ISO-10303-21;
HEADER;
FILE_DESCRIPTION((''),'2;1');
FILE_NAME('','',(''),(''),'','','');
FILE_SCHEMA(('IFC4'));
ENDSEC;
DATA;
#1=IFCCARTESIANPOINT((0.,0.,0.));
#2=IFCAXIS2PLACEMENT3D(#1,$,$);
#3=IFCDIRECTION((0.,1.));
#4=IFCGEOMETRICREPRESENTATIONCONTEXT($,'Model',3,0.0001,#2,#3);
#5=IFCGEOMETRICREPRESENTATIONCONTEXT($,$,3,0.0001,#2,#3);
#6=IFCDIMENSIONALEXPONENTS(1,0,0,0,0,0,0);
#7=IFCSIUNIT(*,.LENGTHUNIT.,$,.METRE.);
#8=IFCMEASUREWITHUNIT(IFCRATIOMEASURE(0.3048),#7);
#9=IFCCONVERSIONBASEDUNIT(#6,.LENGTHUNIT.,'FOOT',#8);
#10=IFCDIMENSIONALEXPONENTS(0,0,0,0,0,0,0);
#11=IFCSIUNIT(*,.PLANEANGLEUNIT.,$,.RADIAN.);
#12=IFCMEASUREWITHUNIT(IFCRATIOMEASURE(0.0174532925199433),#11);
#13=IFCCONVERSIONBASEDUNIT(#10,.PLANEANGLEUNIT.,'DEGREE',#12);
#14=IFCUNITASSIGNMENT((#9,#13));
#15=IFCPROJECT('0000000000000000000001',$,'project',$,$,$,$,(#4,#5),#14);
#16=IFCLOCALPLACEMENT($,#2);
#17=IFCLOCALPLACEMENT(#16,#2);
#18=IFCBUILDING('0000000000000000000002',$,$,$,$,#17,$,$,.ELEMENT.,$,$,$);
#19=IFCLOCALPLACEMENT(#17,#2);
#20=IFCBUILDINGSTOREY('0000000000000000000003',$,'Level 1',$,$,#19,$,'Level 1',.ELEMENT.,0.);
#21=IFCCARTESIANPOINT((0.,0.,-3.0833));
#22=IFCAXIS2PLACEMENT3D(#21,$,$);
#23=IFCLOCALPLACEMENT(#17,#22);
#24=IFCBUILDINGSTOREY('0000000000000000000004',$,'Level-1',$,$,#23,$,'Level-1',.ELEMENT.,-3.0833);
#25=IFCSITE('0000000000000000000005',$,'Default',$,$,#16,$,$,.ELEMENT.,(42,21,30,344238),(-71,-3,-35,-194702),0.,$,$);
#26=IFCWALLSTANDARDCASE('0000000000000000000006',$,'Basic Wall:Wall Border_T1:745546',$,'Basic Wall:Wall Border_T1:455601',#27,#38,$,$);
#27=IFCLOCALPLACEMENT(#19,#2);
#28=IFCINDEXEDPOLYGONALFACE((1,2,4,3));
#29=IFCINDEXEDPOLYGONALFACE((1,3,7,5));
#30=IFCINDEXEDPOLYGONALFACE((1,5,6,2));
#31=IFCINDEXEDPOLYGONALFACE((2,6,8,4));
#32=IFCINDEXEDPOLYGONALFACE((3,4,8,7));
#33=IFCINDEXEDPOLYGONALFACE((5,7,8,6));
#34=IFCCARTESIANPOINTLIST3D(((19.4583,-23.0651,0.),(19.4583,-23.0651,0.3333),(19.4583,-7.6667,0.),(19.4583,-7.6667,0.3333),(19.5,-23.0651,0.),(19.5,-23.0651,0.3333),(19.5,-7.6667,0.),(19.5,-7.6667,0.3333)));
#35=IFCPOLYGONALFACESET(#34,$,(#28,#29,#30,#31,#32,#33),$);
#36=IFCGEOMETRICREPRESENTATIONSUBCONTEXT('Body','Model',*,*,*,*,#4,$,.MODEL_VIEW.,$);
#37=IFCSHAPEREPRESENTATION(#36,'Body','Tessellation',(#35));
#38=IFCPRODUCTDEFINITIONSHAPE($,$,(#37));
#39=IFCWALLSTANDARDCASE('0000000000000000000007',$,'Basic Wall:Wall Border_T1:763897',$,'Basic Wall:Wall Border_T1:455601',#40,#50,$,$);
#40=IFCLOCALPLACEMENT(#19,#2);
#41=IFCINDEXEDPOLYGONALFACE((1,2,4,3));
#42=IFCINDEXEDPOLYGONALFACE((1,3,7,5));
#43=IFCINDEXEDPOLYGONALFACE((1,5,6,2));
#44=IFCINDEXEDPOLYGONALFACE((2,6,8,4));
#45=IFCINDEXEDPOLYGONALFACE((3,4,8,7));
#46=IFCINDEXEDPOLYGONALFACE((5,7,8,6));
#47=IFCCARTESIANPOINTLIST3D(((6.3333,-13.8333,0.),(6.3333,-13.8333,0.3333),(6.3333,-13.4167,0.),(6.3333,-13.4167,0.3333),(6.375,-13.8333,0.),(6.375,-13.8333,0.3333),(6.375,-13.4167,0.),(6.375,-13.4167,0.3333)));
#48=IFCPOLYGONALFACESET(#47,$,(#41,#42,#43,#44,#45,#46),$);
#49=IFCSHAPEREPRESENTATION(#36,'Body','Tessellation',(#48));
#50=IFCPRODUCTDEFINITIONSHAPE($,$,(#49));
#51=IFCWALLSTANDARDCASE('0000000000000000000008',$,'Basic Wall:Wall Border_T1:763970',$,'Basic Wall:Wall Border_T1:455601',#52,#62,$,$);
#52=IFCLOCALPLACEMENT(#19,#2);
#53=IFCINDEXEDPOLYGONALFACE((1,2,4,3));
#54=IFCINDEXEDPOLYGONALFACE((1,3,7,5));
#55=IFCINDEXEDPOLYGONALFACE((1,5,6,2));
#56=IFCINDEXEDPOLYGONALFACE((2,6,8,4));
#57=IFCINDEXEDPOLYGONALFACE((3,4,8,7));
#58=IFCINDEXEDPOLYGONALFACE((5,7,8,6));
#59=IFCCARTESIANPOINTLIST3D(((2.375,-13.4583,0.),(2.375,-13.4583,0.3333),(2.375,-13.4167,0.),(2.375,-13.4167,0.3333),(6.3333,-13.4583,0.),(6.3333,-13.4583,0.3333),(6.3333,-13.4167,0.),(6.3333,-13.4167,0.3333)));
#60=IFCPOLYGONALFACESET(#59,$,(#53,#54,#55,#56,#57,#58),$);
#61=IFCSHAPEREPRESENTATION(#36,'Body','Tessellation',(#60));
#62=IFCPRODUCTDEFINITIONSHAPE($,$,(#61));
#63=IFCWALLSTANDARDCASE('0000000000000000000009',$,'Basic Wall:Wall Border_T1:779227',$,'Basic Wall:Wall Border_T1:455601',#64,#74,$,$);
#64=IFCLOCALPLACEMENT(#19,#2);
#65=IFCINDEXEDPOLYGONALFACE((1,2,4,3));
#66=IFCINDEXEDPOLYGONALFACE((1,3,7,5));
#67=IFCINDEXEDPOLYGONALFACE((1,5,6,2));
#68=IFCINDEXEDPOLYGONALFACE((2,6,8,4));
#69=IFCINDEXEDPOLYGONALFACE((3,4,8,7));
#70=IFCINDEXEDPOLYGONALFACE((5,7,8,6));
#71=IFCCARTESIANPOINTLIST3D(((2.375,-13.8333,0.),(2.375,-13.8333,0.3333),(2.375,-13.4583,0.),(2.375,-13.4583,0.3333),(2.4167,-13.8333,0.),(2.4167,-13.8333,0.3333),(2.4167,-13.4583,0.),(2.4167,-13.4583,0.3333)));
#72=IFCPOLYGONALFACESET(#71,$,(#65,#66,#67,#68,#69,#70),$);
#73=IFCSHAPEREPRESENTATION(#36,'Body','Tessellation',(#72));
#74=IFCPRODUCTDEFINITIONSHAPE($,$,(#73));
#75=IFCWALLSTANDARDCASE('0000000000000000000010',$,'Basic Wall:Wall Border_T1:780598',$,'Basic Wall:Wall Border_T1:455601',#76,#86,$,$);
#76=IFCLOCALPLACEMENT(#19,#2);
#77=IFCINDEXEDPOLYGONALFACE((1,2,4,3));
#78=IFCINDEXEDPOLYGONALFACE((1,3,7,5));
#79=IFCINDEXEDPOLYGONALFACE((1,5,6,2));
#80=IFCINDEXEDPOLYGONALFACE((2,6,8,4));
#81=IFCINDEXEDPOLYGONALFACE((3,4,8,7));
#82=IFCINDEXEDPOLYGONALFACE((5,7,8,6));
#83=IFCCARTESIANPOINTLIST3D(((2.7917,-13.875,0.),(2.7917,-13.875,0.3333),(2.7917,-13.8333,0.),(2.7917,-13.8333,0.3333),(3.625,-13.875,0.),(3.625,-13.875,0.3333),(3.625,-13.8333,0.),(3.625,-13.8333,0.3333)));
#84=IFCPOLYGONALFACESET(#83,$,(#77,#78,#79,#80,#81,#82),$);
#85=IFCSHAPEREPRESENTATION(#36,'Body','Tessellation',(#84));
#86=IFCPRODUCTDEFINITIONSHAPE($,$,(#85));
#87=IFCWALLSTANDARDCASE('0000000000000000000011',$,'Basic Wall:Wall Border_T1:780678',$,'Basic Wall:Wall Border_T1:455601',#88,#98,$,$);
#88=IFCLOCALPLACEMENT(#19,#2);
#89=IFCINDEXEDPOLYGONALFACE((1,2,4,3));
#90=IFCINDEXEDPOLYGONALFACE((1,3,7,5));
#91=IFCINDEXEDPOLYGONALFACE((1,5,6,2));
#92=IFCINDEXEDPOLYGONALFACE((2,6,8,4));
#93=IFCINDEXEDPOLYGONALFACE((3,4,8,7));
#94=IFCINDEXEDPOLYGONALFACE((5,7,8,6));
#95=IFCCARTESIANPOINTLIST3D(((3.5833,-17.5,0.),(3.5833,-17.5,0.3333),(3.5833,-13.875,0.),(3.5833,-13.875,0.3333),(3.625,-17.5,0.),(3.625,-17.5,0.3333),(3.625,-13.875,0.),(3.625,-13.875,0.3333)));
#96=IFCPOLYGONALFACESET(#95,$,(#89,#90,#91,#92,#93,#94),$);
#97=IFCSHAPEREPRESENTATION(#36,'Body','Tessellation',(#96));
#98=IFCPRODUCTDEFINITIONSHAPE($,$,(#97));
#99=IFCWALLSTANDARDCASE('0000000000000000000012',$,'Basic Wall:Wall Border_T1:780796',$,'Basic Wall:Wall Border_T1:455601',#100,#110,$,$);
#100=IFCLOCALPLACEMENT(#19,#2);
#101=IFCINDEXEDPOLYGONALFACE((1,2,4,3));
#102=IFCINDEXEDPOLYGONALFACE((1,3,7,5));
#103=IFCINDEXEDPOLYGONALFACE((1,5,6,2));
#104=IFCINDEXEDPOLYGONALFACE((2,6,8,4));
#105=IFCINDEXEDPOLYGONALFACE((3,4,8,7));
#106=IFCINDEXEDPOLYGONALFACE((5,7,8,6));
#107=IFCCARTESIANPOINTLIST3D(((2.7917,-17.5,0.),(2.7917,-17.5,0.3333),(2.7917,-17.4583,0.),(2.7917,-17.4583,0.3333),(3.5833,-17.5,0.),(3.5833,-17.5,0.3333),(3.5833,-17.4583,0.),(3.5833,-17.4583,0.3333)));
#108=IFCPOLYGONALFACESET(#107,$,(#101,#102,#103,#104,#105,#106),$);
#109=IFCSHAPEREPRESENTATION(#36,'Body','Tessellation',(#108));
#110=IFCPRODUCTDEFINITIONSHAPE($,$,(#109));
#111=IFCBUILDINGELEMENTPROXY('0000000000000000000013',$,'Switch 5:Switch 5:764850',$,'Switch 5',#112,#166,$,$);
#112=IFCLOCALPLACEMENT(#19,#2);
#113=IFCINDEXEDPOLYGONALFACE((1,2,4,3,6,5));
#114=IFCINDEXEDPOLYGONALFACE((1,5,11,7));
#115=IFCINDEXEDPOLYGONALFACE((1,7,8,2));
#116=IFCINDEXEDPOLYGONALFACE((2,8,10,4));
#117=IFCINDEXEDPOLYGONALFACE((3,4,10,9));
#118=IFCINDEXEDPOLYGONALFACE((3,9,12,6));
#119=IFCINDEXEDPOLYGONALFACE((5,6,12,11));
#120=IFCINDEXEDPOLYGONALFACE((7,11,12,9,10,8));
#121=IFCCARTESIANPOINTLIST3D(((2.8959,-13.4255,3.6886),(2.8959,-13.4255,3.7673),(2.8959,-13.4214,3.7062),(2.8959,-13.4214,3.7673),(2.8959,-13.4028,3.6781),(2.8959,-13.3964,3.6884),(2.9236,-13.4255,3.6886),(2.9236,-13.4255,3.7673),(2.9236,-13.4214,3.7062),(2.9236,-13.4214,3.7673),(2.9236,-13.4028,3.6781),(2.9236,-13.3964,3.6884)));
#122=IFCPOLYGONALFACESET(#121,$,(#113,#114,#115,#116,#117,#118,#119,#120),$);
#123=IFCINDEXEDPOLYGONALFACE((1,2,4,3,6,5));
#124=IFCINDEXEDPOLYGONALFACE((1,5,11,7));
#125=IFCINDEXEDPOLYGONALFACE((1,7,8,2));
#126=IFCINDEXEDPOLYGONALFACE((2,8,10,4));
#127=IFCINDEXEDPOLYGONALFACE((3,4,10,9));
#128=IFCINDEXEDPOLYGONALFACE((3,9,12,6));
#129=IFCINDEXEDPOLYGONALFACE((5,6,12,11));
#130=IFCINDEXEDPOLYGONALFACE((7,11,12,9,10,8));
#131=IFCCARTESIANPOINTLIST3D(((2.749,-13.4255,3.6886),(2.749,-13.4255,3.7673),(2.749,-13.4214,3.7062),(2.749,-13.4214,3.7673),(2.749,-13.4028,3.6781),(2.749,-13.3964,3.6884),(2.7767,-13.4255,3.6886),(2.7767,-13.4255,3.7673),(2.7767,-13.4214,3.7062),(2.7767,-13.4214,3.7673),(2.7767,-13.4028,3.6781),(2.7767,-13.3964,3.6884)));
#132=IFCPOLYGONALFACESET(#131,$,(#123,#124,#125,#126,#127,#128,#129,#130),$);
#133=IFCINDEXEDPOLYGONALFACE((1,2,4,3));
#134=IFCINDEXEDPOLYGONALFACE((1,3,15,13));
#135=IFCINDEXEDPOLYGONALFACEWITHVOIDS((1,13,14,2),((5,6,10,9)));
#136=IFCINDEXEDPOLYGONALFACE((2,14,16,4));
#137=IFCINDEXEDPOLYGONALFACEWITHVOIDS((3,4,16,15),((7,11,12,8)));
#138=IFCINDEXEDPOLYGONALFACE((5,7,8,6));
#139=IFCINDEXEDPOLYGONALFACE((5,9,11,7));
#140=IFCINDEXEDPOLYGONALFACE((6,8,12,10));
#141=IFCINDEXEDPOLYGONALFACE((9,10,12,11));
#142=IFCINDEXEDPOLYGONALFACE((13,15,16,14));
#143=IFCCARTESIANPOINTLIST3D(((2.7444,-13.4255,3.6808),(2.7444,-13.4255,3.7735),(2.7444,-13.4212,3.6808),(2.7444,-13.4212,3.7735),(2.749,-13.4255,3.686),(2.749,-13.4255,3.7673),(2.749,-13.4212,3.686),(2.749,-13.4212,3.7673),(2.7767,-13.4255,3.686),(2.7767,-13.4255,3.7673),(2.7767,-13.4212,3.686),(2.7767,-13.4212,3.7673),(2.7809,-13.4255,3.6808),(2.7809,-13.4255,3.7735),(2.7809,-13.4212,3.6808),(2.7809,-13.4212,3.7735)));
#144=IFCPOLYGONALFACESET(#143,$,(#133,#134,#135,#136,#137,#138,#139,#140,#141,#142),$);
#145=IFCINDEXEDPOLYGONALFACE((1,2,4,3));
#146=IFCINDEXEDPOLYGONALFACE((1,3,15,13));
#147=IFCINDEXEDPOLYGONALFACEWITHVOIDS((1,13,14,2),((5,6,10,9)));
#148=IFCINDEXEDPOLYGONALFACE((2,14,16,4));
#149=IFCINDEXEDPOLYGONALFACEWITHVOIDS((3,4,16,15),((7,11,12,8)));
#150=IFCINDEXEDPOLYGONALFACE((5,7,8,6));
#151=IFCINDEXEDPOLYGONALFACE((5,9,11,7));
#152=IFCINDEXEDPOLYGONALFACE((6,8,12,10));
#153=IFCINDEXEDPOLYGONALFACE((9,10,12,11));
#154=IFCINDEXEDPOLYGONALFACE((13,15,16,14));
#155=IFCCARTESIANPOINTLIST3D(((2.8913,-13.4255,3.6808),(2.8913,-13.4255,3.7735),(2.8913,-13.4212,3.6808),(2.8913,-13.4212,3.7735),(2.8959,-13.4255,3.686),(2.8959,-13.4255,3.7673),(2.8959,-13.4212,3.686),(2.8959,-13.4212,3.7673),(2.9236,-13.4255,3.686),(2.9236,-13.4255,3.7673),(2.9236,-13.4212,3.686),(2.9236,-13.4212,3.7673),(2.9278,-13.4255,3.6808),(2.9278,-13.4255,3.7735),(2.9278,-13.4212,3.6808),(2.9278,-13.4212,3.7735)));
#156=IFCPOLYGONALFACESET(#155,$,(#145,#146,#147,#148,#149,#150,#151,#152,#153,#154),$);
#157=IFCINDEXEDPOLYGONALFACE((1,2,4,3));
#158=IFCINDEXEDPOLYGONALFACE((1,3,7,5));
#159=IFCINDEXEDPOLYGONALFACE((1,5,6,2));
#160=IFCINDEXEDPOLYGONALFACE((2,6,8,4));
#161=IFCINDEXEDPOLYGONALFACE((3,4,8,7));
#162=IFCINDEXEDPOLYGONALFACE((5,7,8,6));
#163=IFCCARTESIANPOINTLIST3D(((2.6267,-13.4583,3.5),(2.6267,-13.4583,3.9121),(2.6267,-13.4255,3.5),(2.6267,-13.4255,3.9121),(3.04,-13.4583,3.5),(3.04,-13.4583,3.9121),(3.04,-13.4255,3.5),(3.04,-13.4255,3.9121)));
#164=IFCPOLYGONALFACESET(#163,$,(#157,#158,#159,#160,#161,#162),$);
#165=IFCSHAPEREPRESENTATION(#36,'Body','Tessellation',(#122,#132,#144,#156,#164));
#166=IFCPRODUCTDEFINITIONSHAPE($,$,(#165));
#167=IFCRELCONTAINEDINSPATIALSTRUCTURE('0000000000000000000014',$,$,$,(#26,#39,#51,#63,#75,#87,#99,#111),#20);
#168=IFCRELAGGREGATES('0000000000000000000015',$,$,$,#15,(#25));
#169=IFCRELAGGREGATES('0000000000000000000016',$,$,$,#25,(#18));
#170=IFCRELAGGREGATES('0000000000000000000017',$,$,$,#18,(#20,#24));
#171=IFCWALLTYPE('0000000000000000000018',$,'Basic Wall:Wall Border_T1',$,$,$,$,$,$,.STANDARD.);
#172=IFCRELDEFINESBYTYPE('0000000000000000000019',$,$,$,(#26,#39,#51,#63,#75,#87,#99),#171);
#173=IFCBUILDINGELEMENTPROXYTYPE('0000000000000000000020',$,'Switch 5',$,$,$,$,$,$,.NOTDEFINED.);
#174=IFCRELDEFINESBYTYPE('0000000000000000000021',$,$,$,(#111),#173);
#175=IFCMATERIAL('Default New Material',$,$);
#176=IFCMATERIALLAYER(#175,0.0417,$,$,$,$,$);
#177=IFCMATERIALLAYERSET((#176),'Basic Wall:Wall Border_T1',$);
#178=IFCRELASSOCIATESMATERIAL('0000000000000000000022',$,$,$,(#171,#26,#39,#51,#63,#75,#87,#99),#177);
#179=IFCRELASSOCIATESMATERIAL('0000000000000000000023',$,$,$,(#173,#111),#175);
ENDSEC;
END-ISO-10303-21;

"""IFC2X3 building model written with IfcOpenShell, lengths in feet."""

from ifc_helpers import new_model, entity, si_unit, converted_unit, direction, frame, frame_2d, origin, origin_2d_with_axis, place, context, subcontext, project, spatial, polyline, rectangle, outline, extrude, source, transform, mapped, material, layer, layer_set, layer_usage, type_object, type_shapes, element, save


model = new_model("IFC2X3")

# Units and contexts
model_context = context("Model", 3, precision=0.0001, world=origin(), true_north=direction((0.0, 1.0)))
context_of_model = context(None, 3, precision=0.0001, world=origin(), true_north=direction((0.0, 1.0)))
body_context = subcontext(model_context, "Body", "Model", "MODEL_VIEW")
ifc_project = project(units=[converted_unit("LENGTHUNIT", "FOOT", entity("IfcRatioMeasure", 0.3048), si_unit("LENGTHUNIT", "METRE"), dimensions=[1, 0, 0, 0, 0, 0, 0]), converted_unit("PLANEANGLEUNIT", "DEGREE", entity("IfcRatioMeasure", 0.0174532925199433), si_unit("PLANEANGLEUNIT", "RADIAN"), dimensions=[0, 0, 0, 0, 0, 0, 0])], contexts=[model_context, context_of_model])

# Site, building, storey
site_placement = place(None, origin())
site = spatial("IfcSite", under=ifc_project, at=site_placement, Name="Default", CompositionType="ELEMENT", RefLatitude=(42, 21, 30, 344238), RefLongitude=(-71, -3, -35, -194702), RefElevation=0.0)
building_placement = place(site_placement, origin())
building = spatial("IfcBuilding", under=site, at=building_placement, CompositionType="ELEMENT")
storey_1_placement = place(building_placement, origin())
storey_1 = spatial("IfcBuildingStorey", under=building, at=storey_1_placement, Name="Level 1", LongName="Level 1", CompositionType="ELEMENT", Elevation=0.0)

# Shared definitions
ifc_material_1 = material(Name="Default New Material")

# Shared definitions
storey_2_placement = place(building_placement, frame((0.0, 0.0, -3.0833)))
storey_2 = spatial("IfcBuildingStorey", under=building, at=storey_2_placement, Name="Level-1", LongName="Level-1", CompositionType="ELEMENT", Elevation=-3.0833)

# Walls
ifc_layer_1 = layer(ifc_material_1, 0.0417)
ifc_layer_set_1 = layer_set([ifc_layer_1], Name="Basic Wall:Wall Border_T1")
wall_type_1 = type_object("IfcWallType", Name="Basic Wall:Wall Border_T1", PredefinedType="STANDARD", material=ifc_layer_set_1)
ifc_layer_usage_1 = layer_usage(ifc_layer_set_1, "AXIS2", "POSITIVE", -0.0208)
wall_1_placement = place(storey_1_placement, frame((19.4792, -7.6667, 0.0), z_axis=(0.0, 0.0, 1.0), x_axis=(0.0, -1.0, 0.0)))
element("IfcWallStandardCase", 1, at=wall_1_placement, inside=storey_1, type_object=wall_type_1, material=ifc_layer_usage_1, Name="Basic Wall:Wall Border_T1:745546", ObjectType="Basic Wall:Wall Border_T1:455601", context=body_context, shape_type="SweptSolid", body=[
    extrude(rectangle(XDim=15.3985, YDim=0.0417, at=frame_2d((7.6992, 0.0), x_axis=(-1.0, 0.0))), origin(), (0.0, 0.0, 1.0), 0.3333),
])
ifc_layer_usage_2 = layer_usage(ifc_layer_set_1, "AXIS2", "POSITIVE", -0.0208)
wall_2_placement = place(storey_1_placement, frame((6.3542, -13.8333, 0.0), z_axis=(0.0, 0.0, 1.0), x_axis=(0.0, 1.0, 0.0)))
element("IfcWallStandardCase", 2, at=wall_2_placement, inside=storey_1, type_object=wall_type_1, material=ifc_layer_usage_2, Name="Basic Wall:Wall Border_T1:763897", ObjectType="Basic Wall:Wall Border_T1:455601", context=body_context, shape_type="SweptSolid", body=[
    extrude(rectangle(XDim=0.4167, YDim=0.0417, at=frame_2d((0.2083, 0.0), x_axis=(-1.0, 0.0))), origin(), (0.0, 0.0, 1.0), 0.3333),
])
ifc_layer_usage_3 = layer_usage(ifc_layer_set_1, "AXIS2", "POSITIVE", -0.0208)
wall_3_placement = place(storey_1_placement, frame((6.3333, -13.4375, 0.0), z_axis=(0.0, 0.0, 1.0), x_axis=(-1.0, 0.0, 0.0)))
element("IfcWallStandardCase", 3, at=wall_3_placement, inside=storey_1, type_object=wall_type_1, material=ifc_layer_usage_3, Name="Basic Wall:Wall Border_T1:763970", ObjectType="Basic Wall:Wall Border_T1:455601", context=body_context, shape_type="SweptSolid", body=[
    extrude(rectangle(XDim=3.9583, YDim=0.0417, at=frame_2d((1.9792, 0.0), x_axis=(-1.0, 0.0))), origin(), (0.0, 0.0, 1.0), 0.3333),
])
ifc_layer_usage_4 = layer_usage(ifc_layer_set_1, "AXIS2", "POSITIVE", -0.0208)
wall_4_placement = place(storey_1_placement, frame((2.3958, -13.4583, 0.0), z_axis=(0.0, 0.0, 1.0), x_axis=(0.0, -1.0, 0.0)))
element("IfcWallStandardCase", 4, at=wall_4_placement, inside=storey_1, type_object=wall_type_1, material=ifc_layer_usage_4, Name="Basic Wall:Wall Border_T1:779227", ObjectType="Basic Wall:Wall Border_T1:455601", context=body_context, shape_type="SweptSolid", body=[
    extrude(rectangle(XDim=0.375, YDim=0.0417, at=frame_2d((0.1875, 0.0), x_axis=(-1.0, 0.0))), origin(), (0.0, 0.0, 1.0), 0.3333),
])
ifc_layer_usage_5 = layer_usage(ifc_layer_set_1, "AXIS2", "POSITIVE", -0.0208)
wall_5_placement = place(storey_1_placement, frame((2.7917, -13.8542, 0.0)))
element("IfcWallStandardCase", 5, at=wall_5_placement, inside=storey_1, type_object=wall_type_1, material=ifc_layer_usage_5, Name="Basic Wall:Wall Border_T1:780598", ObjectType="Basic Wall:Wall Border_T1:455601", context=body_context, shape_type="SweptSolid", body=[
    extrude(rectangle(XDim=0.8333, YDim=0.0417, at=frame_2d((0.4167, 0.0), x_axis=(-1.0, 0.0))), origin(), (0.0, 0.0, 1.0), 0.3333),
])
ifc_layer_usage_6 = layer_usage(ifc_layer_set_1, "AXIS2", "POSITIVE", -0.0208)
wall_6_placement = place(storey_1_placement, frame((3.6042, -13.875, 0.0), z_axis=(0.0, 0.0, 1.0), x_axis=(0.0, -1.0, 0.0)))
element("IfcWallStandardCase", 6, at=wall_6_placement, inside=storey_1, type_object=wall_type_1, material=ifc_layer_usage_6, Name="Basic Wall:Wall Border_T1:780678", ObjectType="Basic Wall:Wall Border_T1:455601", context=body_context, shape_type="SweptSolid", body=[
    extrude(rectangle(XDim=3.625, YDim=0.0417, at=frame_2d((1.8125, 0.0), x_axis=(-1.0, 0.0))), origin(), (0.0, 0.0, 1.0), 0.3333),
])
ifc_layer_usage_7 = layer_usage(ifc_layer_set_1, "AXIS2", "POSITIVE", -0.0208)
wall_7_placement = place(storey_1_placement, frame((3.5833, -17.4792, 0.0), z_axis=(0.0, 0.0, 1.0), x_axis=(-1.0, 0.0, 0.0)))
element("IfcWallStandardCase", 7, at=wall_7_placement, inside=storey_1, type_object=wall_type_1, material=ifc_layer_usage_7, Name="Basic Wall:Wall Border_T1:780796", ObjectType="Basic Wall:Wall Border_T1:455601", context=body_context, shape_type="SweptSolid", body=[
    extrude(rectangle(XDim=0.7917, YDim=0.0417, at=frame_2d((0.3958, 0.0), x_axis=(-1.0, 0.0))), origin(), (0.0, 0.0, 1.0), 0.3333),
])

# Building element proxy
building_element_proxy_type_1 = type_object("IfcBuildingElementProxyType", Name="Switch 5", PredefinedType="NOTDEFINED", material=ifc_material_1)
shared_shape_1 = source(origin(), body_context, "Body", "SweptSolid", [
    extrude(outline(polyline([(-0.0255, -0.0308), (-0.0133, -0.0308), (-0.0115, -0.0002), (0.0405, 0.0322), (0.0383, 0.0356), (-0.0285, -0.006), (-0.0255, -0.0308)])), frame((0.0626, 0.0429, 0.216), z_axis=(1.0, 0.0, 0.0), x_axis=(0.0, 0.528865, 0.848706)), (0.0, 0.0, 1.0), 0.0277),
    extrude(outline(polyline([(-0.0255, -0.0308), (-0.0133, -0.0308), (-0.0115, -0.0002), (0.0405, 0.0322), (0.0383, 0.0356), (-0.0285, -0.006), (-0.0255, -0.0308)])), frame((-0.0843, 0.0429, 0.216), z_axis=(1.0, 0.0, 0.0), x_axis=(0.0, 0.528865, 0.848706)), (0.0, 0.0, 1.0), 0.0277),
    extrude(outline(polyline([(-0.0464, -0.0182), (0.0464, -0.0182), (0.0464, 0.0182), (-0.0464, 0.0182), (-0.0464, -0.0182)]), holes=[polyline([(-0.0402, -0.0141), (-0.0402, 0.0136), (0.0411, 0.0136), (0.0411, -0.0141), (-0.0402, -0.0141)])]), frame((-0.0707, 0.0329, 0.2271), z_axis=(0.0, 1.0, 0.0), x_axis=(0.0, 0.0, -1.0)), (0.0, 0.0, 1.0), 0.0042),
    extrude(outline(polyline([(-0.0464, -0.0182), (0.0464, -0.0182), (0.0464, 0.0182), (-0.0464, 0.0182), (-0.0464, -0.0182)]), holes=[polyline([(-0.0402, -0.0141), (-0.0402, 0.0136), (0.0411, 0.0136), (0.0411, -0.0141), (-0.0402, -0.0141)])]), frame((0.0762, 0.0329, 0.2271), z_axis=(0.0, 1.0, 0.0), x_axis=(0.0, 0.0, -1.0)), (0.0, 0.0, 1.0), 0.0042),
    extrude(rectangle(XDim=0.0329, YDim=0.4134, at=origin_2d_with_axis()), frame((0.0, 0.0164, 0.0), z_axis=(0.0, 0.0, 1.0), x_axis=(0.0, -1.0, 0.0)), (0.0, 0.0, 1.0), 0.4121),
])
type_shapes(building_element_proxy_type_1, [shared_shape_1])
proxy_1_placement = place(storey_1_placement, frame((2.8333, -13.4583, 3.5)))
element("IfcBuildingElementProxy", 8, at=proxy_1_placement, inside=storey_1, type_object=building_element_proxy_type_1, material=ifc_material_1, Name="Switch 5:Switch 5:764850", ObjectType="Switch 5", context=body_context, shape_type="MappedRepresentation", body=[
    mapped(shared_shape_1, transform((0.0, 0.0, 0.0), scale=1.0)),
])

save(model, "model.ifc")
